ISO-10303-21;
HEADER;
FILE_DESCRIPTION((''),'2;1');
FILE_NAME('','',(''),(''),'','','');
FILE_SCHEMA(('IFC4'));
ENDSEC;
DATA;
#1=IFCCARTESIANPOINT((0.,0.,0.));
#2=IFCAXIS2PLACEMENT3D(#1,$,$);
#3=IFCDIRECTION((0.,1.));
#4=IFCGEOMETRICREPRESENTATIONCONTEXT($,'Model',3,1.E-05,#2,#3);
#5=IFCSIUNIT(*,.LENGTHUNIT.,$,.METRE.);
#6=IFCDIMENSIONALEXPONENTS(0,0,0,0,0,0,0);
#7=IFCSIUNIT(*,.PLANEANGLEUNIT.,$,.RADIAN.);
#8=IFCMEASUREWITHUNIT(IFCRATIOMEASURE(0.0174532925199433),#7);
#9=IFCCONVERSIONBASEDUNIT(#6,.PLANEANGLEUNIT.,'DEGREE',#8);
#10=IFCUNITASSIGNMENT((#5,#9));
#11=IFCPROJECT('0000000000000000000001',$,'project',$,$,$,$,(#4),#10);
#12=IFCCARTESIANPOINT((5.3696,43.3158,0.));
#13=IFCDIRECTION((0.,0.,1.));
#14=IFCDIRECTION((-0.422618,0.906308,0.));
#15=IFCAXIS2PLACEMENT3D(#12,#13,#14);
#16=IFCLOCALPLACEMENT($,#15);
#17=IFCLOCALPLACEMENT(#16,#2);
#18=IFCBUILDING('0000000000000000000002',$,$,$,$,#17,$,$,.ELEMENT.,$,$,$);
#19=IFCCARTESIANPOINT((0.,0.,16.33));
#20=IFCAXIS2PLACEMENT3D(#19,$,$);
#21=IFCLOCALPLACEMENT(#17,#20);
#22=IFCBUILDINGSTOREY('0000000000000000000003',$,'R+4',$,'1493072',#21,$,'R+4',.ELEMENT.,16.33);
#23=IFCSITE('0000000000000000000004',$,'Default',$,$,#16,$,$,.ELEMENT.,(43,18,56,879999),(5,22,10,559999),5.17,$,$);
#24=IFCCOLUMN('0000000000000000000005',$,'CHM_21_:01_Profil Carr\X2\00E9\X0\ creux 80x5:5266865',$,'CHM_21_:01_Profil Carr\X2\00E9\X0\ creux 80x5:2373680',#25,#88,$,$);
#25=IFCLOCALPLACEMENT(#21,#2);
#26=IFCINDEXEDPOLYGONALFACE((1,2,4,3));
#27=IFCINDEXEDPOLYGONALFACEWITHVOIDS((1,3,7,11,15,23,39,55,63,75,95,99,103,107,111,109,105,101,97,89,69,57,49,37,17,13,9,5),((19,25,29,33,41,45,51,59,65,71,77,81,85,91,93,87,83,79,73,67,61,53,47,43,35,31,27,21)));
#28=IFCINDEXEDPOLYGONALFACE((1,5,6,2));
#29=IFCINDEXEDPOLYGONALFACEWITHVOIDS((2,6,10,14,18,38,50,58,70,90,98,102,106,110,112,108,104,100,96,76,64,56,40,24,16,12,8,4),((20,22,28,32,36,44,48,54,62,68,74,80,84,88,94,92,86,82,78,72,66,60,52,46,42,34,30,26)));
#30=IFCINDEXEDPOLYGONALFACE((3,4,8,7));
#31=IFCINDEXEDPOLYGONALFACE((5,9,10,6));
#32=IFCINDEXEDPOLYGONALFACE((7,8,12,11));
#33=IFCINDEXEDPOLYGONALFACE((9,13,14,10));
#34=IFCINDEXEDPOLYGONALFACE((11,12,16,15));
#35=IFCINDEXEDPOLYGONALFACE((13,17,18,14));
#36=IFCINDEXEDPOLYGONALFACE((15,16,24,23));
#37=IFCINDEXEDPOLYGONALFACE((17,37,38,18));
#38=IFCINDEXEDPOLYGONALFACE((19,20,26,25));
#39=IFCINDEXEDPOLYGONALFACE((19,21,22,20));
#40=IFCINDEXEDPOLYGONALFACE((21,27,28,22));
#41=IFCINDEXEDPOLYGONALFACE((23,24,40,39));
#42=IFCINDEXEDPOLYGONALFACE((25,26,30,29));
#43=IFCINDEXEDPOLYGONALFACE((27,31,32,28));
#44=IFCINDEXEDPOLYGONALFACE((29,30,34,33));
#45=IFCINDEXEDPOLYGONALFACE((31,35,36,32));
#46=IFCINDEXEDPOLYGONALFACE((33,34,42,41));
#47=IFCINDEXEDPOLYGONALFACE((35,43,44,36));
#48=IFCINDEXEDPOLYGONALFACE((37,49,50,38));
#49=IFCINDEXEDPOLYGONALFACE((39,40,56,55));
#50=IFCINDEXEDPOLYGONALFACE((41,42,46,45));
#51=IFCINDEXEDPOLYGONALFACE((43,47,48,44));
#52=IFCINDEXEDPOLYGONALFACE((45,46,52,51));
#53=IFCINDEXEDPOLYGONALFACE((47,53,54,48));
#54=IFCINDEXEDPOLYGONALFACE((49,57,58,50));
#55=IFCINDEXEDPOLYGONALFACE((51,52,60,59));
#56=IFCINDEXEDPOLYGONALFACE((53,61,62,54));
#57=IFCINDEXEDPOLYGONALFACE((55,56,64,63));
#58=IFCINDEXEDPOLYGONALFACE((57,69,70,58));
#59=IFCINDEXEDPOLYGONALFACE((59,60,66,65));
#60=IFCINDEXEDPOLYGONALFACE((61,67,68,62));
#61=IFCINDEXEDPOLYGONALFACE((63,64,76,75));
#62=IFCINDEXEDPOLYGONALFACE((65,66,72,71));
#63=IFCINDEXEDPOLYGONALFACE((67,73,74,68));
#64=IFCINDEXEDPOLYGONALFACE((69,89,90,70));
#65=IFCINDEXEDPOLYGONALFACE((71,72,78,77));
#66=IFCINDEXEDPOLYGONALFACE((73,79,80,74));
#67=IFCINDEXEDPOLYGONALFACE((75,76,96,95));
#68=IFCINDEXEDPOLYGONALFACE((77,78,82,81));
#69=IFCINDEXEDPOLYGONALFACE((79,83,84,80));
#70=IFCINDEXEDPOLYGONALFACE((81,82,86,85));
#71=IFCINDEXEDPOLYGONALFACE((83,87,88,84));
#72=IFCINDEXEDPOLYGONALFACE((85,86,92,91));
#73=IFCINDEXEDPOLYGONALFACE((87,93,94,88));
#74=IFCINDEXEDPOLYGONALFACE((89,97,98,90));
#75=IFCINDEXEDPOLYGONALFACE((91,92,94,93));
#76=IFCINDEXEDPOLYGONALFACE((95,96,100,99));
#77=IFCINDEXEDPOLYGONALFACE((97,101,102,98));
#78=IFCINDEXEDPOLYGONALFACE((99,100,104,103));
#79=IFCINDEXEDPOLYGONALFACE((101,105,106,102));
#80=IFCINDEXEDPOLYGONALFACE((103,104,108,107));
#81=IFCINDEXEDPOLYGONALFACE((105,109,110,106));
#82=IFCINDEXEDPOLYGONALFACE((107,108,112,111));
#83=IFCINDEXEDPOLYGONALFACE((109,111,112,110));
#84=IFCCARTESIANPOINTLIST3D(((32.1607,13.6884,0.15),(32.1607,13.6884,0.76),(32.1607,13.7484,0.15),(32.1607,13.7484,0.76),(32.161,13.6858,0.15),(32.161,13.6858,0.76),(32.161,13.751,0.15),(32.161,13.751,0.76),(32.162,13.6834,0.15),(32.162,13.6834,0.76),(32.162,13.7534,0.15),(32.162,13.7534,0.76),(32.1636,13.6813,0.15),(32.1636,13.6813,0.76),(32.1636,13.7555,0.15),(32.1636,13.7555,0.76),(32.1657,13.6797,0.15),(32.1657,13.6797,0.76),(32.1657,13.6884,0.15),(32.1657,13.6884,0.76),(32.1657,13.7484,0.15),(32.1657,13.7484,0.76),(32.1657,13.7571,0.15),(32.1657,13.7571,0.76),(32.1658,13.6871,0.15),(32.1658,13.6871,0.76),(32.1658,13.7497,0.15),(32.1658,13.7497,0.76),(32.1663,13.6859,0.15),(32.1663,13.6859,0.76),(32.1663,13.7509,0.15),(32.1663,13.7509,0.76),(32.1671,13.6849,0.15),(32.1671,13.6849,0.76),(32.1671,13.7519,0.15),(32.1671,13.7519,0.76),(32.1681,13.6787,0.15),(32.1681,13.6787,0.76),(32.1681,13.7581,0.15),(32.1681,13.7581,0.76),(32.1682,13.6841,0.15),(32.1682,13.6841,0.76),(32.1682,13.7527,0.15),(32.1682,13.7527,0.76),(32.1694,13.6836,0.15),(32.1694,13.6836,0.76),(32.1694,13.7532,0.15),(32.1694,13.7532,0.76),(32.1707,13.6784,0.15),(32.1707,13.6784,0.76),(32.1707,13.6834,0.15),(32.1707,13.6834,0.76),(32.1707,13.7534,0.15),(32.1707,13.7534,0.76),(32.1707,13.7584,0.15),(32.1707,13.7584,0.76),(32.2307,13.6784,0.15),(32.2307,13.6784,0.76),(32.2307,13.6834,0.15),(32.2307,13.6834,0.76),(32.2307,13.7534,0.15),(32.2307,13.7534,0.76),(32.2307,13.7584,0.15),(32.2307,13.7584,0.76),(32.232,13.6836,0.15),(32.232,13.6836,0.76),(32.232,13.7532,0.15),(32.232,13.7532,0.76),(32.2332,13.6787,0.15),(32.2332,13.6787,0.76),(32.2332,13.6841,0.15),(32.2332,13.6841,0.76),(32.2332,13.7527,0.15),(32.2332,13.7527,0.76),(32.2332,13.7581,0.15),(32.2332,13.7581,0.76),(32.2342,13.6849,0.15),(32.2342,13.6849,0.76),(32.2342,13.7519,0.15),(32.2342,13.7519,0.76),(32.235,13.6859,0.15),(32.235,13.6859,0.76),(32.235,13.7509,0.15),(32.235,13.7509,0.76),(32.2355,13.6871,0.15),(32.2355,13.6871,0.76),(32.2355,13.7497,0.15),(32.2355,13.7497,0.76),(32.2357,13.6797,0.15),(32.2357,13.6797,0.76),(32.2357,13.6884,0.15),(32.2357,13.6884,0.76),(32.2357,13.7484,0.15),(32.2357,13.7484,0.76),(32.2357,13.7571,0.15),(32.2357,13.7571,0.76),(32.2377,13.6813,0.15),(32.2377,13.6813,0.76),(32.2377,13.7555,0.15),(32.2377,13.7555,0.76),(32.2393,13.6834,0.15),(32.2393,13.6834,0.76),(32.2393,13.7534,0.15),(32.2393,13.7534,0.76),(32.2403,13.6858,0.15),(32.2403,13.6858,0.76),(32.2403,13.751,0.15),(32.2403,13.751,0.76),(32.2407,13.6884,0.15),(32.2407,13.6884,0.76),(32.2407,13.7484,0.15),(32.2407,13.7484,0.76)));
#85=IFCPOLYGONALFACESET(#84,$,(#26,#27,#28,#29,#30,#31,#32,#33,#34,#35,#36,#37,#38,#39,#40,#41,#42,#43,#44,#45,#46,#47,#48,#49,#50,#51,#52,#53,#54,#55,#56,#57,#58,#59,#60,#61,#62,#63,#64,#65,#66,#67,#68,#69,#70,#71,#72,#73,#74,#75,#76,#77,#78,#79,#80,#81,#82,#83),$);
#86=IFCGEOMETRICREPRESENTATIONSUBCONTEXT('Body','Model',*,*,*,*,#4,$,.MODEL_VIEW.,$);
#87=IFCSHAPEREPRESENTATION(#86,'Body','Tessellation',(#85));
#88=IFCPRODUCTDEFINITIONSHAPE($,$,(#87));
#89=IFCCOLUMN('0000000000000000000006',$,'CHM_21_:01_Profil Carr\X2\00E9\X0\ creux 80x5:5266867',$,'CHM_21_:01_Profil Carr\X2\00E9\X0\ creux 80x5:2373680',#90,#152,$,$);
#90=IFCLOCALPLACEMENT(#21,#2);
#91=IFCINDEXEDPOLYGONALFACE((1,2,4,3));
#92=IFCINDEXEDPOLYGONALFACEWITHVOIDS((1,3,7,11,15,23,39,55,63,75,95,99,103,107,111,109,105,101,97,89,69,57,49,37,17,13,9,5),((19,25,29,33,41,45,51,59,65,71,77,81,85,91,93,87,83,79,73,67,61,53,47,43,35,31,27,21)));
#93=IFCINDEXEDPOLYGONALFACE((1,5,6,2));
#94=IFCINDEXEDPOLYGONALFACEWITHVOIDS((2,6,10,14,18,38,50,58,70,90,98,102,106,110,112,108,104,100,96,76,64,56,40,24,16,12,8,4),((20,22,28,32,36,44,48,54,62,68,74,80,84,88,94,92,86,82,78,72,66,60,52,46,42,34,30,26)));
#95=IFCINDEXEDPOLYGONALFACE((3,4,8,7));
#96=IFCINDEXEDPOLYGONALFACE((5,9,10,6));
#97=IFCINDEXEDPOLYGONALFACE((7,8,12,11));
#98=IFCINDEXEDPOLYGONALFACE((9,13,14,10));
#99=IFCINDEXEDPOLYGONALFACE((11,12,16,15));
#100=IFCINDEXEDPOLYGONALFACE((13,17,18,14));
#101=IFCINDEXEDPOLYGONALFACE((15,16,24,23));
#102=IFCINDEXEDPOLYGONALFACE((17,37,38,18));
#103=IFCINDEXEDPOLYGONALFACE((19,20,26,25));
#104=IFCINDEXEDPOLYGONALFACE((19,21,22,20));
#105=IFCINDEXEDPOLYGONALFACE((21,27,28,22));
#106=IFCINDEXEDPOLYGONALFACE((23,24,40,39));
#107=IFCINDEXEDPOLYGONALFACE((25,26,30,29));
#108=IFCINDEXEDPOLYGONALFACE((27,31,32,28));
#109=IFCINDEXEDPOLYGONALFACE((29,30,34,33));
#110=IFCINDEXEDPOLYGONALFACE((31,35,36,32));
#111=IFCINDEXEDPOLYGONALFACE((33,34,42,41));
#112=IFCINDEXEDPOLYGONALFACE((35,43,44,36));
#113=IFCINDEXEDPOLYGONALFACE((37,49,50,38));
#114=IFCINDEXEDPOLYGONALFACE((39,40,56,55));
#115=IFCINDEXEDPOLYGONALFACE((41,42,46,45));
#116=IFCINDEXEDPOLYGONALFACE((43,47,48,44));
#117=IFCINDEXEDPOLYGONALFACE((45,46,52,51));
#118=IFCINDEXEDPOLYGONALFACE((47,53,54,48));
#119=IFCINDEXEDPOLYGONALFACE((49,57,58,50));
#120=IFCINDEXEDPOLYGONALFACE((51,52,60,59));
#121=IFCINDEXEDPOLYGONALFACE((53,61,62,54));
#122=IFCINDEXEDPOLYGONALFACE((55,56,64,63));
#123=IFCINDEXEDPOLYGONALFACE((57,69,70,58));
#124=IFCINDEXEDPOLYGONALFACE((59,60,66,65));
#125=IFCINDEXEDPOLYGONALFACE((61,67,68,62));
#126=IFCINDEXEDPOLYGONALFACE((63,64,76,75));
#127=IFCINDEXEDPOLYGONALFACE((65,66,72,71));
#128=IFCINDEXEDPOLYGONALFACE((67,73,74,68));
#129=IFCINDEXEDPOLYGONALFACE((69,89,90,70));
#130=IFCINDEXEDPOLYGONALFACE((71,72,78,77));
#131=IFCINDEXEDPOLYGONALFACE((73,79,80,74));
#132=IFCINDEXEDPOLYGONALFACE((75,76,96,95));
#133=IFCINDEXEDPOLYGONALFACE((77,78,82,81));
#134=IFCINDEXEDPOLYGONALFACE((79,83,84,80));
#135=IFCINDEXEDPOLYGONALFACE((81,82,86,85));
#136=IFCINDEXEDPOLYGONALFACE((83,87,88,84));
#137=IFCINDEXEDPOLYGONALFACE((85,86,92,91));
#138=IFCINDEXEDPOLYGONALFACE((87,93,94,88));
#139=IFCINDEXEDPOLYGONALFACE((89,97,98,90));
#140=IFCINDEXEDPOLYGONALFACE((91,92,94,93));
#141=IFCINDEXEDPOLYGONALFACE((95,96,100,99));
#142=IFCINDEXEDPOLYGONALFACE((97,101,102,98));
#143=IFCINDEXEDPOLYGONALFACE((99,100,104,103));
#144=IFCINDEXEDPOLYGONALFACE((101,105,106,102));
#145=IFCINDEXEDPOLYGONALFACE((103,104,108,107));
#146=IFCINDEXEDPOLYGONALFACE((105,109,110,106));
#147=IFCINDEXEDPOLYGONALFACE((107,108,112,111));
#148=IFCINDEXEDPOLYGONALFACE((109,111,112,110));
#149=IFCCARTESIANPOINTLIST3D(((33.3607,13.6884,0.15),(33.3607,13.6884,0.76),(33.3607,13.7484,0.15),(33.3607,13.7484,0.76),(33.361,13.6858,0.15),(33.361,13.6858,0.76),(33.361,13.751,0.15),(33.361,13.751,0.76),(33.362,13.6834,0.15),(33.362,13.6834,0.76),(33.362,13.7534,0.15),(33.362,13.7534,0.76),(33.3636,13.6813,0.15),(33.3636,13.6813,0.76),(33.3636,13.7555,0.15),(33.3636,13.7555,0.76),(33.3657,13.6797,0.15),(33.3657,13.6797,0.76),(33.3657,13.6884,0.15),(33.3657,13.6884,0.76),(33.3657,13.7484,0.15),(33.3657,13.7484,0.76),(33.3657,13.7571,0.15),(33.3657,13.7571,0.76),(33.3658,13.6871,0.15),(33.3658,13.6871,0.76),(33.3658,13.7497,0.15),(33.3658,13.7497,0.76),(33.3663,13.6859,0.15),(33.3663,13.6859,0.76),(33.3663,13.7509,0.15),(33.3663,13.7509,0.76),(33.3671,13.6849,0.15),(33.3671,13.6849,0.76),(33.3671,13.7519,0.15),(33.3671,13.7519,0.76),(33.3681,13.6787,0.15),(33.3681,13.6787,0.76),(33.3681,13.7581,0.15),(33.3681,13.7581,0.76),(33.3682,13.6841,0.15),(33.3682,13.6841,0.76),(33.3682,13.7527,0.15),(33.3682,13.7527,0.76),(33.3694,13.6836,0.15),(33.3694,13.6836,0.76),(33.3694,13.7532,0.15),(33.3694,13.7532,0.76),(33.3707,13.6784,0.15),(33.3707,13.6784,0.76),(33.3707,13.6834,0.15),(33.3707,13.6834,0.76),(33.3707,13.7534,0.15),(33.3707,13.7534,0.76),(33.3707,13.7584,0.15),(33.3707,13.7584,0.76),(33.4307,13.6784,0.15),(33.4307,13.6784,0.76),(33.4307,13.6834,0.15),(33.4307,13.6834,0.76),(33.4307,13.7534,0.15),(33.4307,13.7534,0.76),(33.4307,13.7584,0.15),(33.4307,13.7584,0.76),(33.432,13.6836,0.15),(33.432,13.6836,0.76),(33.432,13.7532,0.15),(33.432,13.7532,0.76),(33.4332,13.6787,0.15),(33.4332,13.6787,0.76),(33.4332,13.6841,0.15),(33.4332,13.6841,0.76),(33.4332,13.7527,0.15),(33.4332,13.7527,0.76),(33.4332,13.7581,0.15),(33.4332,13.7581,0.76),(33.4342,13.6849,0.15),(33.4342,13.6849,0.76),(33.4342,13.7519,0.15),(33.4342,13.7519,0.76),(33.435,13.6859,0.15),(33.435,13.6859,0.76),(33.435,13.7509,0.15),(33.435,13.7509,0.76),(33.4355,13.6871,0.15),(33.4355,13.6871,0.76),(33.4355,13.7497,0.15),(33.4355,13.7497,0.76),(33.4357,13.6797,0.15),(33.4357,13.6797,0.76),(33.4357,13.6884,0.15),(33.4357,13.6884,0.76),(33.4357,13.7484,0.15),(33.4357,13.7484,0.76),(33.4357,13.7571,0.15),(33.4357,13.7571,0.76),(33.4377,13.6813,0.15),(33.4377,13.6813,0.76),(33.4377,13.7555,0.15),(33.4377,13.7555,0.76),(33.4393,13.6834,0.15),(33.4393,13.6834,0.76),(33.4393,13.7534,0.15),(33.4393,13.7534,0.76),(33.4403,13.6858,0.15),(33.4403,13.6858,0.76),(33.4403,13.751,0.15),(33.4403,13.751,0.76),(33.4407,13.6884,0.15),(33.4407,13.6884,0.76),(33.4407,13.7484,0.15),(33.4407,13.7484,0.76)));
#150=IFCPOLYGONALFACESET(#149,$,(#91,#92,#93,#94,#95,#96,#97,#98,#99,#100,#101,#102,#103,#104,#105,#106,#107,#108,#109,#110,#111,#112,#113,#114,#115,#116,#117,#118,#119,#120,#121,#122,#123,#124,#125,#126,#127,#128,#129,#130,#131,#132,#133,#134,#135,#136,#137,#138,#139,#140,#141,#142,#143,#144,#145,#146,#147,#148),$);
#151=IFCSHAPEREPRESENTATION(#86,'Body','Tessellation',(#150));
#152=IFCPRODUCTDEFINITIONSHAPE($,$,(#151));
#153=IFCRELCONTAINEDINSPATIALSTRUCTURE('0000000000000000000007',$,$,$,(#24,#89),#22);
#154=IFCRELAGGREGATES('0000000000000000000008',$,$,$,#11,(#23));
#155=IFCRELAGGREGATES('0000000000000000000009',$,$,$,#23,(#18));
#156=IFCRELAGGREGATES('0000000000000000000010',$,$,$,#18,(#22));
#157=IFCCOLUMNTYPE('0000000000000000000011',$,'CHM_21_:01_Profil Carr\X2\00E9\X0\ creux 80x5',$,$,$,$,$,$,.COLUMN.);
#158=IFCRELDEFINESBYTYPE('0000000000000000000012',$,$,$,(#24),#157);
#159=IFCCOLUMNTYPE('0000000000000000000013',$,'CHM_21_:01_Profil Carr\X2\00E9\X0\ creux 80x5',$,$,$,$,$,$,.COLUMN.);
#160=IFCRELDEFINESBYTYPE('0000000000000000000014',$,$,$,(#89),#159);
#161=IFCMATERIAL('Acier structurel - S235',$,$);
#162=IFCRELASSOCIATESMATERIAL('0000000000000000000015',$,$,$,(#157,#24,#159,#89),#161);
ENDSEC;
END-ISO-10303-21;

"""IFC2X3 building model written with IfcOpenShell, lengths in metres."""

from ifc_helpers import new_model, entity, si_unit, converted_unit, direction, frame, frame_2d, origin, place, context, subcontext, project, spatial, polyline, circle_curve, parameter, trimmed, segment, composite_curve, outline, extrude, source, transform, mapped, material, type_object, type_shapes, element, save


model = new_model("IFC2X3")

# Units and contexts
model_context = context("Model", 3, precision=1e-05, world=origin(), true_north=direction((0.0, 1.0)))
body_context = subcontext(model_context, "Body", "Model", "MODEL_VIEW")
ifc_project = project(units=[si_unit("LENGTHUNIT", "METRE"), converted_unit("PLANEANGLEUNIT", "DEGREE", entity("IfcRatioMeasure", 0.0174532925199433), si_unit("PLANEANGLEUNIT", "RADIAN"), dimensions=[0, 0, 0, 0, 0, 0, 0])], contexts=[model_context])

# Site, building, storey
site_placement = place(None, frame((5.3696, 43.3158, 0.0), z_axis=(0.0, 0.0, 1.0), x_axis=(-0.422618, 0.906308, 0.0)))
site = spatial("IfcSite", under=ifc_project, at=site_placement, Name="Default", CompositionType="ELEMENT", RefLatitude=(43, 18, 56, 879999), RefLongitude=(5, 22, 10, 559999), RefElevation=5.17)
building_placement = place(site_placement, origin())
building = spatial("IfcBuilding", under=site, at=building_placement, CompositionType="ELEMENT")
storey_placement = place(building_placement, frame((0.0, 0.0, 16.33)))
storey = spatial("IfcBuildingStorey", under=building, at=storey_placement, Name="R+4", ObjectType="1493072", LongName="R+4", CompositionType="ELEMENT", Elevation=16.33)

# Columns
ifc_material_1 = material(Name="Acier structurel - S235")
column_type_1 = type_object("IfcColumnType", Name="CHM_21_:01_Profil Carré creux 80x5", PredefinedType="COLUMN", material=ifc_material_1)
shared_shape_1 = source(origin(), body_context, "Body", "SweptSolid", [
    extrude(outline(composite_curve([segment(polyline([(-0.03, -0.04), (0.03, -0.04)]), True, "CONTINUOUS"), segment(trimmed(circle_curve(frame_2d((0.03, -0.03), x_axis=(-1.0, 0.0)), 0.01), [parameter(90.0)], [parameter(180.0)], True, "PARAMETER"), True, "CONTINUOUS"), segment(polyline([(0.04, -0.03), (0.04, 0.03)]), True, "CONTINUOUS"), segment(trimmed(circle_curve(frame_2d((0.03, 0.03), x_axis=(-1.0, 0.0)), 0.01), [parameter(180.0)], [parameter(270.0)], True, "PARAMETER"), True, "CONTINUOUS"), segment(polyline([(0.03, 0.04), (-0.03, 0.04)]), True, "CONTINUOUS"), segment(trimmed(circle_curve(frame_2d((-0.03, 0.03), x_axis=(-1.0, 0.0)), 0.01), [parameter(270.0)], [parameter(360.0)], True, "PARAMETER"), True, "CONTINUOUS"), segment(polyline([(-0.04, 0.03), (-0.04, -0.03)]), True, "CONTINUOUS"), segment(trimmed(circle_curve(frame_2d((-0.03, -0.03), x_axis=(-1.0, 0.0)), 0.01), [parameter(360.0)], [parameter(90.0)], True, "PARAMETER"), True, "CONTINUOUS")], self_intersect=False), holes=[composite_curve([segment(trimmed(circle_curve(frame_2d((-0.03, -0.03), x_axis=(-1.0, 0.0)), 0.005), [parameter(360.0)], [parameter(90.0)], True, "PARAMETER"), False, "CONTINUOUS"), segment(polyline([(-0.035, -0.03), (-0.035, 0.03)]), True, "CONTINUOUS"), segment(trimmed(circle_curve(frame_2d((-0.03, 0.03), x_axis=(-1.0, 0.0)), 0.005), [parameter(270.0)], [parameter(360.0)], True, "PARAMETER"), False, "CONTINUOUS"), segment(polyline([(-0.03, 0.035), (0.03, 0.035)]), True, "CONTINUOUS"), segment(trimmed(circle_curve(frame_2d((0.03, 0.03), x_axis=(-1.0, 0.0)), 0.005), [parameter(180.0)], [parameter(270.0)], True, "PARAMETER"), False, "CONTINUOUS"), segment(polyline([(0.035, 0.03), (0.035, -0.03)]), True, "CONTINUOUS"), segment(trimmed(circle_curve(frame_2d((0.03, -0.03), x_axis=(-1.0, 0.0)), 0.005), [parameter(90.0)], [parameter(180.0)], True, "PARAMETER"), False, "CONTINUOUS"), segment(polyline([(0.03, -0.035), (-0.03, -0.035)]), True, "CONTINUOUS")], self_intersect=False)]), frame((32.2007, 13.7184, 16.48), z_axis=(0.0, 0.0, 1.0), x_axis=(0.0, 1.0, 0.0)), (0.0, 0.0, 1.0), 0.61),
])
type_shapes(column_type_1, [shared_shape_1])
column_1_placement = place(storey_placement, frame((0.0, 0.0, -16.33)))
element("IfcColumn", 1, at=column_1_placement, inside=storey, type_object=column_type_1, material=ifc_material_1, Name="CHM_21_:01_Profil Carré creux 80x5:5266865", ObjectType="CHM_21_:01_Profil Carré creux 80x5:2373680", context=body_context, shape_type="MappedRepresentation", body=[
    mapped(shared_shape_1, transform((0.0, 0.0, 0.0), scale=1.0)),
])
column_type_2 = type_object("IfcColumnType", Name="CHM_21_:01_Profil Carré creux 80x5", PredefinedType="COLUMN", material=ifc_material_1)
shared_shape_2 = source(origin(), body_context, "Body", "SweptSolid", [
    extrude(outline(composite_curve([segment(polyline([(-0.03, -0.04), (0.03, -0.04)]), True, "CONTINUOUS"), segment(trimmed(circle_curve(frame_2d((0.03, -0.03), x_axis=(-1.0, 0.0)), 0.01), [parameter(90.0)], [parameter(180.0)], True, "PARAMETER"), True, "CONTINUOUS"), segment(polyline([(0.04, -0.03), (0.04, 0.03)]), True, "CONTINUOUS"), segment(trimmed(circle_curve(frame_2d((0.03, 0.03), x_axis=(-1.0, 0.0)), 0.01), [parameter(180.0)], [parameter(270.0)], True, "PARAMETER"), True, "CONTINUOUS"), segment(polyline([(0.03, 0.04), (-0.03, 0.04)]), True, "CONTINUOUS"), segment(trimmed(circle_curve(frame_2d((-0.03, 0.03), x_axis=(-1.0, 0.0)), 0.01), [parameter(270.0)], [parameter(360.0)], True, "PARAMETER"), True, "CONTINUOUS"), segment(polyline([(-0.04, 0.03), (-0.04, -0.03)]), True, "CONTINUOUS"), segment(trimmed(circle_curve(frame_2d((-0.03, -0.03), x_axis=(-1.0, 0.0)), 0.01), [parameter(360.0)], [parameter(90.0)], True, "PARAMETER"), True, "CONTINUOUS")], self_intersect=False), holes=[composite_curve([segment(trimmed(circle_curve(frame_2d((-0.03, -0.03), x_axis=(-1.0, 0.0)), 0.005), [parameter(360.0)], [parameter(90.0)], True, "PARAMETER"), False, "CONTINUOUS"), segment(polyline([(-0.035, -0.03), (-0.035, 0.03)]), True, "CONTINUOUS"), segment(trimmed(circle_curve(frame_2d((-0.03, 0.03), x_axis=(-1.0, 0.0)), 0.005), [parameter(270.0)], [parameter(360.0)], True, "PARAMETER"), False, "CONTINUOUS"), segment(polyline([(-0.03, 0.035), (0.03, 0.035)]), True, "CONTINUOUS"), segment(trimmed(circle_curve(frame_2d((0.03, 0.03), x_axis=(-1.0, 0.0)), 0.005), [parameter(180.0)], [parameter(270.0)], True, "PARAMETER"), False, "CONTINUOUS"), segment(polyline([(0.035, 0.03), (0.035, -0.03)]), True, "CONTINUOUS"), segment(trimmed(circle_curve(frame_2d((0.03, -0.03), x_axis=(-1.0, 0.0)), 0.005), [parameter(90.0)], [parameter(180.0)], True, "PARAMETER"), False, "CONTINUOUS"), segment(polyline([(0.03, -0.035), (-0.03, -0.035)]), True, "CONTINUOUS")], self_intersect=False)]), frame((33.4007, 13.7184, 16.48), z_axis=(0.0, 0.0, 1.0), x_axis=(0.0, 1.0, 0.0)), (0.0, 0.0, 1.0), 0.61),
])
type_shapes(column_type_2, [shared_shape_2])
column_2_placement = place(storey_placement, frame((0.0, 0.0, -16.33)))
element("IfcColumn", 2, at=column_2_placement, inside=storey, type_object=column_type_2, material=ifc_material_1, Name="CHM_21_:01_Profil Carré creux 80x5:5266867", ObjectType="CHM_21_:01_Profil Carré creux 80x5:2373680", context=body_context, shape_type="MappedRepresentation", body=[
    mapped(shared_shape_2, transform((0.0, 0.0, 0.0), scale=1.0)),
])

save(model, "model.ifc")
